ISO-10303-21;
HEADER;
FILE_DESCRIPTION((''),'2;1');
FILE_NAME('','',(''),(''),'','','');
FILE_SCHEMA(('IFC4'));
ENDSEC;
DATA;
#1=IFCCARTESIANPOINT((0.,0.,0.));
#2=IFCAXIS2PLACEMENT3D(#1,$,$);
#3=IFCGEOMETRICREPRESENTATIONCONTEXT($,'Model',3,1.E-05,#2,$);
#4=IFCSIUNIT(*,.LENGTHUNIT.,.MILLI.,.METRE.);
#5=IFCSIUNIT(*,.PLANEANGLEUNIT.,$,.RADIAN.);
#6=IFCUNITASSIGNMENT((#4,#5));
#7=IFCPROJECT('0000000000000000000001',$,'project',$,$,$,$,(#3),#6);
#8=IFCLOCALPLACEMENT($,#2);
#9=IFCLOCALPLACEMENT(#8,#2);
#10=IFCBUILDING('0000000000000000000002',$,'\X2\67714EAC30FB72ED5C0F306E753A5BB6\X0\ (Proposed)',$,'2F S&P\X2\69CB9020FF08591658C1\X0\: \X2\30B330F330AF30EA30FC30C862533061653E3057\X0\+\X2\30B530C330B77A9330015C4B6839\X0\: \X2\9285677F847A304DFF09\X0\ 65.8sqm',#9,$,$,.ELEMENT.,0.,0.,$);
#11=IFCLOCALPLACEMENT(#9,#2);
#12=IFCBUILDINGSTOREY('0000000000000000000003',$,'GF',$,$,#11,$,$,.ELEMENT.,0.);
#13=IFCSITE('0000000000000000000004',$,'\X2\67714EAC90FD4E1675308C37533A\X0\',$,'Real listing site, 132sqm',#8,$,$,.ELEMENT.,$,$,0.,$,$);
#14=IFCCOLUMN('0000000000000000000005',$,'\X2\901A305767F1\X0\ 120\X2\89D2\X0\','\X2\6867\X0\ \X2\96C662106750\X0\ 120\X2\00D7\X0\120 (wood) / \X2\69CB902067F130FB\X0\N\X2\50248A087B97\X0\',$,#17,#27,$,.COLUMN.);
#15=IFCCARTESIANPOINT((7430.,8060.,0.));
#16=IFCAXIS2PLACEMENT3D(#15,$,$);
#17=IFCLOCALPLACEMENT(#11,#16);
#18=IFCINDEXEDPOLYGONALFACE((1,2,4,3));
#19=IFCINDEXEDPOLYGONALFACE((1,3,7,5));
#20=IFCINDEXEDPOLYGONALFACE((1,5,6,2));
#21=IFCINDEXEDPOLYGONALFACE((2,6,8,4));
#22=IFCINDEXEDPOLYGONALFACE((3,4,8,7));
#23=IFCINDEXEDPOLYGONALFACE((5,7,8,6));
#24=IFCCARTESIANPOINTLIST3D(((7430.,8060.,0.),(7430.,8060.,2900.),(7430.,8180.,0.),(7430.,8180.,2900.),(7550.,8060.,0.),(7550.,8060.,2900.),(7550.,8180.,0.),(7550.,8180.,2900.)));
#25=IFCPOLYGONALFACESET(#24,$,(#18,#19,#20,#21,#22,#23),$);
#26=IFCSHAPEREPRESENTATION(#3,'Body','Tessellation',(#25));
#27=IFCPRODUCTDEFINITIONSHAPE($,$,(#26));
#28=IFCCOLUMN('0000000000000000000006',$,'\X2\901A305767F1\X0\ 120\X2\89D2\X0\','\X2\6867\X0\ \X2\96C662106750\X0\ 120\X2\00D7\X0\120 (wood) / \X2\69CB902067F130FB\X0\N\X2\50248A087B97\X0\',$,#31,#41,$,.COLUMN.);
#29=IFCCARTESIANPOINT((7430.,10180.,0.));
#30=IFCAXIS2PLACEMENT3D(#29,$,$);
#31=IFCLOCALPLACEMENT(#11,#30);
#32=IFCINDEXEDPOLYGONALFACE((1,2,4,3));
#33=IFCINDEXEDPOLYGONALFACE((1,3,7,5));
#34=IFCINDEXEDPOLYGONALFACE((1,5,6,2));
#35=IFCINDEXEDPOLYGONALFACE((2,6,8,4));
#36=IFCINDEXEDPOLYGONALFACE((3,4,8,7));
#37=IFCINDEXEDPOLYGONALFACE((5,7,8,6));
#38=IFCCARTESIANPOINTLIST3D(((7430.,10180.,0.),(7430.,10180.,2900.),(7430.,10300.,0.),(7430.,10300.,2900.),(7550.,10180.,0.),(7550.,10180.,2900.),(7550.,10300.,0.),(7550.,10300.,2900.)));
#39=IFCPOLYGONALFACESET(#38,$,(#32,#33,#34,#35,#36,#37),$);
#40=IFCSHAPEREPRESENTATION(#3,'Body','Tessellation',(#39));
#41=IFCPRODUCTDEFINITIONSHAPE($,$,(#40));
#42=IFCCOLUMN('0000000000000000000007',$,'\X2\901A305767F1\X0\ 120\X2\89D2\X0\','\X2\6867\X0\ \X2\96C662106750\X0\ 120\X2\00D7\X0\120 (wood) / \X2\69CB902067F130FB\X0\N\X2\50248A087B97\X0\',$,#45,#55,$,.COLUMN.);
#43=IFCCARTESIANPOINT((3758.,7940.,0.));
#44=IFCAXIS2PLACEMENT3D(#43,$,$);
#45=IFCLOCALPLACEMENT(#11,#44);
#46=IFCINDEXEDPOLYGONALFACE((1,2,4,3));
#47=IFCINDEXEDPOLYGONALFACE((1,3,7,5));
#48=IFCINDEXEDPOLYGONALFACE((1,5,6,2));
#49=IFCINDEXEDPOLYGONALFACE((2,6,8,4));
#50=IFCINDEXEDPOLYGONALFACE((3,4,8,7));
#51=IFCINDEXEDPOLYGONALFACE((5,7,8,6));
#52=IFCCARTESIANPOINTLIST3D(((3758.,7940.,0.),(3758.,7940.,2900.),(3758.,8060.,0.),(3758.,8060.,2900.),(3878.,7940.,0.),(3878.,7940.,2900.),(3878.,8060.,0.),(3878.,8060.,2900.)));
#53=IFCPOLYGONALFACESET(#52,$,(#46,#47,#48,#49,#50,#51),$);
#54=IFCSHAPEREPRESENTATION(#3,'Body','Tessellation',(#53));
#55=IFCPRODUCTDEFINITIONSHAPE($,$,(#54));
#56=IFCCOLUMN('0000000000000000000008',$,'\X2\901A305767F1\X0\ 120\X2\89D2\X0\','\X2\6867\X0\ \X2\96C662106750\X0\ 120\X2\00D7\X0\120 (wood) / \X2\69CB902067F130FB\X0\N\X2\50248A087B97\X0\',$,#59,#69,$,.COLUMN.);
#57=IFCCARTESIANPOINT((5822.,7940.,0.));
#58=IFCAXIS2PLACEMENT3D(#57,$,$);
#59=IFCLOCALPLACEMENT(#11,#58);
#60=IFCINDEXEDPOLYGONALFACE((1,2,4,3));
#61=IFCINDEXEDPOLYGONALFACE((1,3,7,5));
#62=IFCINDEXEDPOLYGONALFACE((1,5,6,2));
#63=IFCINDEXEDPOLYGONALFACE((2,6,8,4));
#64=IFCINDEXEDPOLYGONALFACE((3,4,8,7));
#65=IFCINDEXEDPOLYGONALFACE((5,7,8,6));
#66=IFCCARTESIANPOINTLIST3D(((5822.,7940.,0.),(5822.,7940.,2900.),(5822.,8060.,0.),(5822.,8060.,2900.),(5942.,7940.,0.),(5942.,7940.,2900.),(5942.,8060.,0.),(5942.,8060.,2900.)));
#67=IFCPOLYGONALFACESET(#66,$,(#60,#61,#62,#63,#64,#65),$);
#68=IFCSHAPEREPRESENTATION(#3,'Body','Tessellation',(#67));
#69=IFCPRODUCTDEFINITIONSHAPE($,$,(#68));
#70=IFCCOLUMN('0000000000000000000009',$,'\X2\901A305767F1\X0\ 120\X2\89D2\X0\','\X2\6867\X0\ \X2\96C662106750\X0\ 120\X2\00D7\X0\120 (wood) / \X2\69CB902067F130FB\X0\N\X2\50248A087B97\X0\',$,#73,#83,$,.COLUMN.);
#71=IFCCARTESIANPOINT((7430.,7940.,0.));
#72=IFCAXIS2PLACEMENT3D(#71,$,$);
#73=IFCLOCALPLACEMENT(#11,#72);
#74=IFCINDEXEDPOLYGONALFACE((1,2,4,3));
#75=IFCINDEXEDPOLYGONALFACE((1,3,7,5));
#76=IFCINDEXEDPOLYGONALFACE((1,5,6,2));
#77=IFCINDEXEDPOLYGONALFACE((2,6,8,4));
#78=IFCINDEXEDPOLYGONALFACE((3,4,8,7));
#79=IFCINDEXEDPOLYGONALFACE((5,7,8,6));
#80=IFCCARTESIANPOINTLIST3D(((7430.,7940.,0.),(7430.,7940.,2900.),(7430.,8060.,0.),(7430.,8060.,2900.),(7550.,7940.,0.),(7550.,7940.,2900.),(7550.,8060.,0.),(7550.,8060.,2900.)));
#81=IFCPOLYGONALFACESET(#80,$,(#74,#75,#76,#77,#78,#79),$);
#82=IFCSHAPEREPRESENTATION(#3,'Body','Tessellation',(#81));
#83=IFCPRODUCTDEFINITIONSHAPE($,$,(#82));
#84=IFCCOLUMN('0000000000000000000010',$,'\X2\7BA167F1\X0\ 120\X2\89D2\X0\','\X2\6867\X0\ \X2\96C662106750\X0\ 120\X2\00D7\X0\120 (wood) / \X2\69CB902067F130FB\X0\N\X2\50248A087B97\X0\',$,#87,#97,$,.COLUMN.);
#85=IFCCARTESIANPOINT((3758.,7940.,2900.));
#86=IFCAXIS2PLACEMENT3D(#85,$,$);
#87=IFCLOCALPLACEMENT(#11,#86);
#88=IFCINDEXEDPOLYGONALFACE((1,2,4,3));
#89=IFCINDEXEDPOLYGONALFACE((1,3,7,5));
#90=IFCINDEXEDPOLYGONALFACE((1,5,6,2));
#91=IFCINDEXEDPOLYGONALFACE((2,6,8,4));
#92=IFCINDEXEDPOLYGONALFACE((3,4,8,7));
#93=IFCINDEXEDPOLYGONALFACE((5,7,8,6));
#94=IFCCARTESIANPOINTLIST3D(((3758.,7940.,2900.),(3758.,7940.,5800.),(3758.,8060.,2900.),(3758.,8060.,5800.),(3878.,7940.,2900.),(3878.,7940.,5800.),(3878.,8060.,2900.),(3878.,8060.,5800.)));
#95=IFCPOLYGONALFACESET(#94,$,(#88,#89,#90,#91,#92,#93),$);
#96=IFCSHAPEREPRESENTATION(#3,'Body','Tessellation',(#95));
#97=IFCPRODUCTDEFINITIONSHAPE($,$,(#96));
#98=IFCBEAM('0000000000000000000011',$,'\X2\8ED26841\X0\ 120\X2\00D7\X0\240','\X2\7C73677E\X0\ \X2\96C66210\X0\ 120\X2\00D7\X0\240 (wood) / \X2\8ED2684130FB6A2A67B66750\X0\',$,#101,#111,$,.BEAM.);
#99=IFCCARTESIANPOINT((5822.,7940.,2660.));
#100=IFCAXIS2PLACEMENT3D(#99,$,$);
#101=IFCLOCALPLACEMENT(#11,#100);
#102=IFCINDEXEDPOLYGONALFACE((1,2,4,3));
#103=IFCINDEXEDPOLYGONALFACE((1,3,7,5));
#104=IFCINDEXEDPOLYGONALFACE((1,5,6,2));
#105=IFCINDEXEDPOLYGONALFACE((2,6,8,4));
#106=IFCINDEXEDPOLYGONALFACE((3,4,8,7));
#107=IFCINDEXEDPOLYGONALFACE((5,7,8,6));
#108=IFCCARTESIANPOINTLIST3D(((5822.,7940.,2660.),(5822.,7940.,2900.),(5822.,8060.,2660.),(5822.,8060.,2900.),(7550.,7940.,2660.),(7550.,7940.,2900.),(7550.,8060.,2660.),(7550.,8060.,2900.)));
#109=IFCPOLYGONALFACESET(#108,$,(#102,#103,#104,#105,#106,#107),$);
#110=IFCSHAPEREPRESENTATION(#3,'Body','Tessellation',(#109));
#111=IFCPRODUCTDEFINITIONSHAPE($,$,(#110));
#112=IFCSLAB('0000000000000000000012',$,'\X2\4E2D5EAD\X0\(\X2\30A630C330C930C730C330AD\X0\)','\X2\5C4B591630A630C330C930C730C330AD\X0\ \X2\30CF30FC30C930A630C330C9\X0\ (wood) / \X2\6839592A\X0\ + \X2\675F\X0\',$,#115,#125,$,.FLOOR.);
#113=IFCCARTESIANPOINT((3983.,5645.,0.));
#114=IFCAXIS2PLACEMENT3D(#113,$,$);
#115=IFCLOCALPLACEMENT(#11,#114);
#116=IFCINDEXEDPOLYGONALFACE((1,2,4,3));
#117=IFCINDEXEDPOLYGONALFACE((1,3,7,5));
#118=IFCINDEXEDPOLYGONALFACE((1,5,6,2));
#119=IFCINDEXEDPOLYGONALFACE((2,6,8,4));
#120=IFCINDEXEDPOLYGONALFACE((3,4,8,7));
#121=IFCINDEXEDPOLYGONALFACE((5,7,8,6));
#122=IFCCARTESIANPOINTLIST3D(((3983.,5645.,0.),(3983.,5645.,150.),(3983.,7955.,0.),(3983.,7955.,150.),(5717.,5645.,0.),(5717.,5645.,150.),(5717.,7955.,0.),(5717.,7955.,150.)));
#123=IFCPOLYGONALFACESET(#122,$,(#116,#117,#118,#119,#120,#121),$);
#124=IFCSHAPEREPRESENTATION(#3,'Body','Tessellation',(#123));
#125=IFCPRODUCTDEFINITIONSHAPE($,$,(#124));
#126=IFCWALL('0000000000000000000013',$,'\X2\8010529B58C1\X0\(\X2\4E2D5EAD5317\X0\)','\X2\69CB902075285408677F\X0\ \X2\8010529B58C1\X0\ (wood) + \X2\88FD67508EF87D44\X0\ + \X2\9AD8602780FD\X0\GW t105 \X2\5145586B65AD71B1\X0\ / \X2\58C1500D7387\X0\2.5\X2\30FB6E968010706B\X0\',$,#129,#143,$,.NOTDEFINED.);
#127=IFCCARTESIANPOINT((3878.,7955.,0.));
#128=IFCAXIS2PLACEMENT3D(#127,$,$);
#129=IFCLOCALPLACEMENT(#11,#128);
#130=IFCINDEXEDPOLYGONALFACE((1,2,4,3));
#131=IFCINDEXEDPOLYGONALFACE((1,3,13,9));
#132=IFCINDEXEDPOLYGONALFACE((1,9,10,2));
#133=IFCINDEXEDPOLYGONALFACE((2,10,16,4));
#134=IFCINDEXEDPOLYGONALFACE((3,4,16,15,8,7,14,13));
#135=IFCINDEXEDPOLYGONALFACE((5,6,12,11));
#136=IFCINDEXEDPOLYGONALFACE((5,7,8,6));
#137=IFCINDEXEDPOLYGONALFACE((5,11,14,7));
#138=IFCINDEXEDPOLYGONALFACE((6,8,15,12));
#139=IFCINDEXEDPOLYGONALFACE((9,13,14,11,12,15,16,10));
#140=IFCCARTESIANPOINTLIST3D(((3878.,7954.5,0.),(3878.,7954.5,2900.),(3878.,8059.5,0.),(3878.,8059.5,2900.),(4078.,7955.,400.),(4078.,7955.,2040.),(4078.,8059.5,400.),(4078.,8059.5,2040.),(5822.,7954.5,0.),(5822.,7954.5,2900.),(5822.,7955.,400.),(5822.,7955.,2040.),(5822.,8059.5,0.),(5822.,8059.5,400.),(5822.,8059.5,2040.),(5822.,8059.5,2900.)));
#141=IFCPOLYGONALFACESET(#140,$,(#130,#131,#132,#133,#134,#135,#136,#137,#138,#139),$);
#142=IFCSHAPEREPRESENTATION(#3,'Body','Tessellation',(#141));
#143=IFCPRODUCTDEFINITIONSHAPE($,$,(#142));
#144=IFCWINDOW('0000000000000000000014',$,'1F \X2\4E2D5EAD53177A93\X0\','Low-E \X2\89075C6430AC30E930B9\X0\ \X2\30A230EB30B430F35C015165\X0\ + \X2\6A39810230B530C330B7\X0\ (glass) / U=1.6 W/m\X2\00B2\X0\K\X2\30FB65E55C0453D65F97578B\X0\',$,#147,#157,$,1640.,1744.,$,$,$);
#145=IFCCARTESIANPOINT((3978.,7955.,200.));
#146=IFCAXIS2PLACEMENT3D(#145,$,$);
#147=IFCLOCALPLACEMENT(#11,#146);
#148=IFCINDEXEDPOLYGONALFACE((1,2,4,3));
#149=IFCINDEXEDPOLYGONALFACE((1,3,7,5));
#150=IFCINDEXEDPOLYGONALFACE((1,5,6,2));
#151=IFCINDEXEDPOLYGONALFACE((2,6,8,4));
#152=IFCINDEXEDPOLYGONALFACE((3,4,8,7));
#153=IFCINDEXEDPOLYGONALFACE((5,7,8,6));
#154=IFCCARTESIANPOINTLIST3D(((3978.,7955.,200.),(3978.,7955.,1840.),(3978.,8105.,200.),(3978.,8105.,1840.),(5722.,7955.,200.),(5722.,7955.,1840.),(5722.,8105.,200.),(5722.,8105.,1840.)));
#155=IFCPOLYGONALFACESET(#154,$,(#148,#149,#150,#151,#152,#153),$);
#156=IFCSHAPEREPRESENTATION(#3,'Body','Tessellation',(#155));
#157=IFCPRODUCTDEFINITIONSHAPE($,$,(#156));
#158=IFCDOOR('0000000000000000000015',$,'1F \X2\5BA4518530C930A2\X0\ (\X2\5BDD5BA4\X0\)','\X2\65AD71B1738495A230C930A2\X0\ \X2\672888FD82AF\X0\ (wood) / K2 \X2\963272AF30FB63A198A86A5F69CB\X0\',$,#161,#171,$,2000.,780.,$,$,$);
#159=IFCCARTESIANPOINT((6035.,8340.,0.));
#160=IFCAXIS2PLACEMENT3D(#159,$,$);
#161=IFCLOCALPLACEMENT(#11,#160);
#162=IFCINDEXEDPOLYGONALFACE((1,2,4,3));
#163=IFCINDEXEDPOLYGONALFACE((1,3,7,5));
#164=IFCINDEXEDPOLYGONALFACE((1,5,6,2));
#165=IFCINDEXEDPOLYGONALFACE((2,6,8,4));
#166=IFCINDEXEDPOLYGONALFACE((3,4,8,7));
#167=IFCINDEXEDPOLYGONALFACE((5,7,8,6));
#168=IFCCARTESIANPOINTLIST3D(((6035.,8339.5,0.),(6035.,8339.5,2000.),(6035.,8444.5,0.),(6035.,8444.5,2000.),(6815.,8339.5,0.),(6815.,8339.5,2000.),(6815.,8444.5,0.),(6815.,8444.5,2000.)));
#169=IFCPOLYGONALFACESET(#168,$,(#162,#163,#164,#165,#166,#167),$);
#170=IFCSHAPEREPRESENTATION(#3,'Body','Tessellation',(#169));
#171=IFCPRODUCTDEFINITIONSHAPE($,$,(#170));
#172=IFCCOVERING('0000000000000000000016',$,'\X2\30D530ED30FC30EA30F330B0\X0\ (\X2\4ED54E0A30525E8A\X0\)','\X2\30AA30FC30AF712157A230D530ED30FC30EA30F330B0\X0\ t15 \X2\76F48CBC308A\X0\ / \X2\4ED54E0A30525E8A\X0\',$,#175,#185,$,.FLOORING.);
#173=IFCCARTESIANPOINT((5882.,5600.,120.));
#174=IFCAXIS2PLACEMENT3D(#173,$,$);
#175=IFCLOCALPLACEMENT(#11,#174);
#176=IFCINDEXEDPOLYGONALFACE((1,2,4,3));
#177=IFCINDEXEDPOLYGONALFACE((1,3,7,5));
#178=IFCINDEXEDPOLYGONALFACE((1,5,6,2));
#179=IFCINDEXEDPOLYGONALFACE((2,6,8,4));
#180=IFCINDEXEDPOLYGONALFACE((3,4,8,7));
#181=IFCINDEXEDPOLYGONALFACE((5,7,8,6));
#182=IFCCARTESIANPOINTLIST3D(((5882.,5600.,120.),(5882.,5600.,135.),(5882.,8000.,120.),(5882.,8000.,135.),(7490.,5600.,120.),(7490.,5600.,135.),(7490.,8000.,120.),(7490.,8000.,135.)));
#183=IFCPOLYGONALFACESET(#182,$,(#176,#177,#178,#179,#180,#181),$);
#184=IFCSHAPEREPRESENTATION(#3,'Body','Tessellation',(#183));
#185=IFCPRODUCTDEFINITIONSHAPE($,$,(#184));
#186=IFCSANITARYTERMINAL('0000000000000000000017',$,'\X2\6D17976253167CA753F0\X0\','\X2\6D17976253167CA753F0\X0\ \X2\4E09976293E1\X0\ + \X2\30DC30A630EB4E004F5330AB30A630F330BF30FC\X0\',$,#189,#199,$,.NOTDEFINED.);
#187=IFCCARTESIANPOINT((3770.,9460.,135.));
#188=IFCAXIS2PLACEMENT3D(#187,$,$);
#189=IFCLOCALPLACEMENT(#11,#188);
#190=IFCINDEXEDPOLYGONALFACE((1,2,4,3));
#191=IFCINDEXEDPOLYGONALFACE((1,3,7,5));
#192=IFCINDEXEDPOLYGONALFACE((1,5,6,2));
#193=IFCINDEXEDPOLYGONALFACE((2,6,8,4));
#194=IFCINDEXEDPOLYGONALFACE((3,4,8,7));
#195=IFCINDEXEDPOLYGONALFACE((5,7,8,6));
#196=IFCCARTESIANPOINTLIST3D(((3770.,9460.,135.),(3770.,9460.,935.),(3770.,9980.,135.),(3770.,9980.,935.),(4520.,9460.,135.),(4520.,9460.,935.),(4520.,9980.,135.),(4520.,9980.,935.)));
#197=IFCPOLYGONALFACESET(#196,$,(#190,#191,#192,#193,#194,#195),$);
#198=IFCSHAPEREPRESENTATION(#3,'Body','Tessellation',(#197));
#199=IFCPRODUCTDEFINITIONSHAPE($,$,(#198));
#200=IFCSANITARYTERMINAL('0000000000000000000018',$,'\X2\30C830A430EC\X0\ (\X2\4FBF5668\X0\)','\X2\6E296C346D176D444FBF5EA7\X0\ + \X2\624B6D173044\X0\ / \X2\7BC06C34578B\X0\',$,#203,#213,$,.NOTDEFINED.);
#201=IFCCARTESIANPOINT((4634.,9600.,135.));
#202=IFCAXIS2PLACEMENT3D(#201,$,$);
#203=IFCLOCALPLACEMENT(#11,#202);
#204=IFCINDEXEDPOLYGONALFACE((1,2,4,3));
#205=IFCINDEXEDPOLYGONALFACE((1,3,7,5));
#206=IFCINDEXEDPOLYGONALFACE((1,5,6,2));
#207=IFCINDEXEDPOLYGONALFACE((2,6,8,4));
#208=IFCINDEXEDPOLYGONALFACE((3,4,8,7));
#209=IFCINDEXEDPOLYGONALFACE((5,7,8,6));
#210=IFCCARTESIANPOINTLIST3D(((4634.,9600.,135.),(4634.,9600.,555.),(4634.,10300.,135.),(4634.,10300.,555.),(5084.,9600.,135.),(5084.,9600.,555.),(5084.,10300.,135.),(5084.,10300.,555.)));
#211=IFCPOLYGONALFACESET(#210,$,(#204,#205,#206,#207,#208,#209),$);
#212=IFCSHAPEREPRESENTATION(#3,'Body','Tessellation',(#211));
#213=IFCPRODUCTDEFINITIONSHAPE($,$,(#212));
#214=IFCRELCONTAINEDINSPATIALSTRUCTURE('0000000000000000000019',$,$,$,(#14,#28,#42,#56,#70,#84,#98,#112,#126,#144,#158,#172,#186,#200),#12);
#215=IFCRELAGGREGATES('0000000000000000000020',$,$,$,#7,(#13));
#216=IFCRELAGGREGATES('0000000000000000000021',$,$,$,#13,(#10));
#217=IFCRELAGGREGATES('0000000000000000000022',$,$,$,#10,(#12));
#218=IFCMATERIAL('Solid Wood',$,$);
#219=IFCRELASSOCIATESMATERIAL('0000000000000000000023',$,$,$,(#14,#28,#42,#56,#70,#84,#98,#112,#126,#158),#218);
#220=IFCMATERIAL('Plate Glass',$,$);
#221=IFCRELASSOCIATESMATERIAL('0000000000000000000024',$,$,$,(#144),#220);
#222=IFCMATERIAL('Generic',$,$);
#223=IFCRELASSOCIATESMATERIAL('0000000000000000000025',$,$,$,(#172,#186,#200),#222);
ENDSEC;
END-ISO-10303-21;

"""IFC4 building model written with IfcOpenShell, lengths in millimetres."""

from ifc_helpers import new_model, si_unit, frame, frame_2d, origin, place, context, project, spatial, rectangle, extrude, material, element, fill, save


model = new_model("IFC4")

# Units and contexts
model_context = context("Model", 3, precision=1e-05, world=origin())
ifc_project = project(units=[si_unit("LENGTHUNIT", "METRE", prefix="MILLI"), si_unit("PLANEANGLEUNIT", "RADIAN")], contexts=[model_context])

# Site, building, storey
site_placement = place(None, origin())
site = spatial("IfcSite", under=ifc_project, at=site_placement, Name="東京都世田谷区", ObjectType="Real listing site, 132sqm", CompositionType="ELEMENT", RefElevation=0.0)
building_placement = place(site_placement, origin())
building = spatial("IfcBuilding", under=site, at=building_placement, Name="東京・狭小の町家 (Proposed)", ObjectType="2F S&P構造（外壁: コンクリート打ち放し+サッシ窓、屋根: 銅板葺き） 65.8sqm", CompositionType="ELEMENT", ElevationOfRefHeight=0.0, ElevationOfTerrain=0.0)
storey_placement = place(building_placement, origin())
storey = spatial("IfcBuildingStorey", under=building, at=storey_placement, Name="GF", CompositionType="ELEMENT", Elevation=0.0)

# Columns
ifc_material_1 = material(Name="Solid Wood")
column_1_placement = place(storey_placement, frame((7430.0, 8060.0, 0.0)))
element("IfcColumn", 1, at=column_1_placement, inside=storey, material=ifc_material_1, Name="通し柱 120角", Description="桧 集成材 120×120 (wood) / 構造柱・N値計算", PredefinedType="COLUMN", context=model_context, shape_type="SweptSolid", body=[
    extrude(rectangle(XDim=120.0, YDim=120.0, at=frame_2d((60.0, 60.0))), frame((7430.0, 8060.0, 0.0)), (0.0, 0.0, 1.0), 2900.0),
])
column_2_placement = place(storey_placement, frame((7430.0, 10180.0, 0.0)))
element("IfcColumn", 2, at=column_2_placement, inside=storey, material=ifc_material_1, Name="通し柱 120角", Description="桧 集成材 120×120 (wood) / 構造柱・N値計算", PredefinedType="COLUMN", context=model_context, shape_type="SweptSolid", body=[
    extrude(rectangle(XDim=120.0, YDim=120.0, at=frame_2d((60.0, 60.0))), frame((7430.0, 10180.0, 0.0)), (0.0, 0.0, 1.0), 2900.0),
])
column_3_placement = place(storey_placement, frame((3758.0, 7940.0, 0.0)))
element("IfcColumn", 3, at=column_3_placement, inside=storey, material=ifc_material_1, Name="通し柱 120角", Description="桧 集成材 120×120 (wood) / 構造柱・N値計算", PredefinedType="COLUMN", context=model_context, shape_type="SweptSolid", body=[
    extrude(rectangle(XDim=120.0, YDim=120.0, at=frame_2d((60.0, 60.0))), frame((3758.0, 7940.0, 0.0)), (0.0, 0.0, 1.0), 2900.0),
])
column_4_placement = place(storey_placement, frame((5822.0, 7940.0, 0.0)))
element("IfcColumn", 4, at=column_4_placement, inside=storey, material=ifc_material_1, Name="通し柱 120角", Description="桧 集成材 120×120 (wood) / 構造柱・N値計算", PredefinedType="COLUMN", context=model_context, shape_type="SweptSolid", body=[
    extrude(rectangle(XDim=120.0, YDim=120.0, at=frame_2d((60.0, 60.0))), frame((5822.0, 7940.0, 0.0)), (0.0, 0.0, 1.0), 2900.0),
])
column_5_placement = place(storey_placement, frame((7430.0, 7940.0, 0.0)))
element("IfcColumn", 5, at=column_5_placement, inside=storey, material=ifc_material_1, Name="通し柱 120角", Description="桧 集成材 120×120 (wood) / 構造柱・N値計算", PredefinedType="COLUMN", context=model_context, shape_type="SweptSolid", body=[
    extrude(rectangle(XDim=120.0, YDim=120.0, at=frame_2d((60.0, 60.0))), frame((7430.0, 7940.0, 0.0)), (0.0, 0.0, 1.0), 2900.0),
])
column_6_placement = place(storey_placement, frame((3758.0, 7940.0, 2900.0)))
element("IfcColumn", 6, at=column_6_placement, inside=storey, material=ifc_material_1, Name="管柱 120角", Description="桧 集成材 120×120 (wood) / 構造柱・N値計算", PredefinedType="COLUMN", context=model_context, shape_type="SweptSolid", body=[
    extrude(rectangle(XDim=120.0, YDim=120.0, at=frame_2d((60.0, 60.0))), frame((3758.0, 7940.0, 2900.0)), (0.0, 0.0, 1.0), 2900.0),
])

# Beam
beam_1_placement = place(storey_placement, frame((5822.0, 7940.0, 2660.0)))
element("IfcBeam", 7, at=beam_1_placement, inside=storey, material=ifc_material_1, Name="軒桁 120×240", Description="米松 集成 120×240 (wood) / 軒桁・横架材", PredefinedType="BEAM", context=model_context, shape_type="SweptSolid", body=[
    extrude(rectangle(XDim=1728.0, YDim=120.0, at=frame_2d((864.0, 60.0))), frame((5822.0, 7940.0, 2660.0)), (0.0, 0.0, 1.0), 240.0),
])

# Slab
slab_placement = place(storey_placement, frame((3983.0, 5645.0, 0.0)))
element("IfcSlab", 8, at=slab_placement, inside=storey, material=ifc_material_1, Name="中庭(ウッドデッキ)", Description="屋外ウッドデッキ ハードウッド (wood) / 根太 + 束", PredefinedType="FLOOR", context=model_context, shape_type="SweptSolid", body=[
    extrude(rectangle(XDim=1734.0, YDim=2310.0, at=frame_2d((867.0, 1155.0))), frame((3983.0, 5645.0, 0.0)), (0.0, 0.0, 1.0), 150.0),
])

# Wall, opening, window
wall_1_placement = place(storey_placement, frame((3878.0, 7955.0, 0.0)))
wall_1 = element("IfcWall", 9, at=wall_1_placement, inside=storey, material=ifc_material_1, Name="耐力壁(中庭北)", Description="構造用合板 耐力壁 (wood) + 製材軸組 + 高性能GW t105 充填断熱 / 壁倍率2.5・準耐火", PredefinedType="NOTDEFINED", context=model_context, shape_type="SweptSolid", body=[
    extrude(rectangle(XDim=1944.0, YDim=105.0, at=frame_2d((972.0, 52.0))), frame((3878.0, 7955.0, 0.0)), (0.0, 0.0, 1.0), 2900.0),
])
opening_placement = place(storey_placement, frame((3978.0, 7955.0, 200.0)))
opening = element("IfcOpeningElement", 10, at=opening_placement, cuts=wall_1, PredefinedType="NOTDEFINED", context=model_context, shape_type="SweptSolid", body=[
    extrude(rectangle(XDim=1744.0, YDim=150.0, at=frame_2d((872.0, 75.0))), frame((3978.0, 7955.0, 200.0)), (0.0, 0.0, 1.0), 1640.0),
])
ifc_material_2 = material(Name="Plate Glass")
window_placement = place(storey_placement, frame((3978.0, 7955.0, 200.0)))
window = element("IfcWindow", 11, at=window_placement, inside=storey, material=ifc_material_2, Name="1F 中庭北窓", Description="Low-E 複層ガラス アルゴン封入 + 樹脂サッシ (glass) / U=1.6 W/m²K・日射取得型", OverallHeight=1640.0, OverallWidth=1744.0, context=model_context, shape_type="SweptSolid", body=[
    extrude(rectangle(XDim=1744.0, YDim=150.0, at=frame_2d((872.0, 75.0))), frame((3978.0, 7955.0, 200.0)), (0.0, 0.0, 1.0), 1640.0),
])
fill(opening, window)

# Door
door_placement = place(storey_placement, frame((6035.0, 8340.0, 0.0)))
element("IfcDoor", 12, at=door_placement, inside=storey, material=ifc_material_1, Name="1F 室内ドア (寝室)", Description="断熱玄関ドア 木製芯 (wood) / K2 防犯・採風機構", OverallHeight=2000.0, OverallWidth=780.0, context=model_context, shape_type="SweptSolid", body=[
    extrude(rectangle(XDim=780.0, YDim=105.0, at=frame_2d((390.0, 52.0))), frame((6035.0, 8340.0, 0.0)), (0.0, 0.0, 1.0), 2000.0),
])

# Covering
ifc_material_3 = material(Name="Generic")
covering_placement = place(storey_placement, frame((5882.0, 5600.0, 120.0)))
element("IfcCovering", 13, at=covering_placement, inside=storey, material=ifc_material_3, Name="フローリング (仕上げ床)", Description="オーク無垢フローリング t15 直貼り / 仕上げ床", PredefinedType="FLOORING", context=model_context, shape_type="SweptSolid", body=[
    extrude(rectangle(XDim=1608.0, YDim=2400.0, at=frame_2d((804.0, 1200.0))), frame((5882.0, 5600.0, 120.0)), (0.0, 0.0, 1.0), 15.0),
])

# Sanitary terminals
sanitary_terminal_1_placement = place(storey_placement, frame((3770.0, 9460.0, 135.0)))
element("IfcSanitaryTerminal", 14, at=sanitary_terminal_1_placement, inside=storey, material=ifc_material_3, Name="洗面化粧台", Description="洗面化粧台 三面鏡 + ボウル一体カウンター", PredefinedType="NOTDEFINED", context=model_context, shape_type="SweptSolid", body=[
    extrude(rectangle(XDim=750.0, YDim=520.0, at=frame_2d((375.0, 260.0))), frame((3770.0, 9460.0, 135.0)), (0.0, 0.0, 1.0), 800.0),
])
sanitary_terminal_2_placement = place(storey_placement, frame((4634.0, 9600.0, 135.0)))
element("IfcSanitaryTerminal", 15, at=sanitary_terminal_2_placement, inside=storey, material=ifc_material_3, Name="トイレ (便器)", Description="温水洗浄便座 + 手洗い / 節水型", PredefinedType="NOTDEFINED", context=model_context, shape_type="SweptSolid", body=[
    extrude(rectangle(XDim=450.0, YDim=700.0, at=frame_2d((225.0, 350.0))), frame((4634.0, 9600.0, 135.0)), (0.0, 0.0, 1.0), 420.0),
])

save(model, "model.ifc")
